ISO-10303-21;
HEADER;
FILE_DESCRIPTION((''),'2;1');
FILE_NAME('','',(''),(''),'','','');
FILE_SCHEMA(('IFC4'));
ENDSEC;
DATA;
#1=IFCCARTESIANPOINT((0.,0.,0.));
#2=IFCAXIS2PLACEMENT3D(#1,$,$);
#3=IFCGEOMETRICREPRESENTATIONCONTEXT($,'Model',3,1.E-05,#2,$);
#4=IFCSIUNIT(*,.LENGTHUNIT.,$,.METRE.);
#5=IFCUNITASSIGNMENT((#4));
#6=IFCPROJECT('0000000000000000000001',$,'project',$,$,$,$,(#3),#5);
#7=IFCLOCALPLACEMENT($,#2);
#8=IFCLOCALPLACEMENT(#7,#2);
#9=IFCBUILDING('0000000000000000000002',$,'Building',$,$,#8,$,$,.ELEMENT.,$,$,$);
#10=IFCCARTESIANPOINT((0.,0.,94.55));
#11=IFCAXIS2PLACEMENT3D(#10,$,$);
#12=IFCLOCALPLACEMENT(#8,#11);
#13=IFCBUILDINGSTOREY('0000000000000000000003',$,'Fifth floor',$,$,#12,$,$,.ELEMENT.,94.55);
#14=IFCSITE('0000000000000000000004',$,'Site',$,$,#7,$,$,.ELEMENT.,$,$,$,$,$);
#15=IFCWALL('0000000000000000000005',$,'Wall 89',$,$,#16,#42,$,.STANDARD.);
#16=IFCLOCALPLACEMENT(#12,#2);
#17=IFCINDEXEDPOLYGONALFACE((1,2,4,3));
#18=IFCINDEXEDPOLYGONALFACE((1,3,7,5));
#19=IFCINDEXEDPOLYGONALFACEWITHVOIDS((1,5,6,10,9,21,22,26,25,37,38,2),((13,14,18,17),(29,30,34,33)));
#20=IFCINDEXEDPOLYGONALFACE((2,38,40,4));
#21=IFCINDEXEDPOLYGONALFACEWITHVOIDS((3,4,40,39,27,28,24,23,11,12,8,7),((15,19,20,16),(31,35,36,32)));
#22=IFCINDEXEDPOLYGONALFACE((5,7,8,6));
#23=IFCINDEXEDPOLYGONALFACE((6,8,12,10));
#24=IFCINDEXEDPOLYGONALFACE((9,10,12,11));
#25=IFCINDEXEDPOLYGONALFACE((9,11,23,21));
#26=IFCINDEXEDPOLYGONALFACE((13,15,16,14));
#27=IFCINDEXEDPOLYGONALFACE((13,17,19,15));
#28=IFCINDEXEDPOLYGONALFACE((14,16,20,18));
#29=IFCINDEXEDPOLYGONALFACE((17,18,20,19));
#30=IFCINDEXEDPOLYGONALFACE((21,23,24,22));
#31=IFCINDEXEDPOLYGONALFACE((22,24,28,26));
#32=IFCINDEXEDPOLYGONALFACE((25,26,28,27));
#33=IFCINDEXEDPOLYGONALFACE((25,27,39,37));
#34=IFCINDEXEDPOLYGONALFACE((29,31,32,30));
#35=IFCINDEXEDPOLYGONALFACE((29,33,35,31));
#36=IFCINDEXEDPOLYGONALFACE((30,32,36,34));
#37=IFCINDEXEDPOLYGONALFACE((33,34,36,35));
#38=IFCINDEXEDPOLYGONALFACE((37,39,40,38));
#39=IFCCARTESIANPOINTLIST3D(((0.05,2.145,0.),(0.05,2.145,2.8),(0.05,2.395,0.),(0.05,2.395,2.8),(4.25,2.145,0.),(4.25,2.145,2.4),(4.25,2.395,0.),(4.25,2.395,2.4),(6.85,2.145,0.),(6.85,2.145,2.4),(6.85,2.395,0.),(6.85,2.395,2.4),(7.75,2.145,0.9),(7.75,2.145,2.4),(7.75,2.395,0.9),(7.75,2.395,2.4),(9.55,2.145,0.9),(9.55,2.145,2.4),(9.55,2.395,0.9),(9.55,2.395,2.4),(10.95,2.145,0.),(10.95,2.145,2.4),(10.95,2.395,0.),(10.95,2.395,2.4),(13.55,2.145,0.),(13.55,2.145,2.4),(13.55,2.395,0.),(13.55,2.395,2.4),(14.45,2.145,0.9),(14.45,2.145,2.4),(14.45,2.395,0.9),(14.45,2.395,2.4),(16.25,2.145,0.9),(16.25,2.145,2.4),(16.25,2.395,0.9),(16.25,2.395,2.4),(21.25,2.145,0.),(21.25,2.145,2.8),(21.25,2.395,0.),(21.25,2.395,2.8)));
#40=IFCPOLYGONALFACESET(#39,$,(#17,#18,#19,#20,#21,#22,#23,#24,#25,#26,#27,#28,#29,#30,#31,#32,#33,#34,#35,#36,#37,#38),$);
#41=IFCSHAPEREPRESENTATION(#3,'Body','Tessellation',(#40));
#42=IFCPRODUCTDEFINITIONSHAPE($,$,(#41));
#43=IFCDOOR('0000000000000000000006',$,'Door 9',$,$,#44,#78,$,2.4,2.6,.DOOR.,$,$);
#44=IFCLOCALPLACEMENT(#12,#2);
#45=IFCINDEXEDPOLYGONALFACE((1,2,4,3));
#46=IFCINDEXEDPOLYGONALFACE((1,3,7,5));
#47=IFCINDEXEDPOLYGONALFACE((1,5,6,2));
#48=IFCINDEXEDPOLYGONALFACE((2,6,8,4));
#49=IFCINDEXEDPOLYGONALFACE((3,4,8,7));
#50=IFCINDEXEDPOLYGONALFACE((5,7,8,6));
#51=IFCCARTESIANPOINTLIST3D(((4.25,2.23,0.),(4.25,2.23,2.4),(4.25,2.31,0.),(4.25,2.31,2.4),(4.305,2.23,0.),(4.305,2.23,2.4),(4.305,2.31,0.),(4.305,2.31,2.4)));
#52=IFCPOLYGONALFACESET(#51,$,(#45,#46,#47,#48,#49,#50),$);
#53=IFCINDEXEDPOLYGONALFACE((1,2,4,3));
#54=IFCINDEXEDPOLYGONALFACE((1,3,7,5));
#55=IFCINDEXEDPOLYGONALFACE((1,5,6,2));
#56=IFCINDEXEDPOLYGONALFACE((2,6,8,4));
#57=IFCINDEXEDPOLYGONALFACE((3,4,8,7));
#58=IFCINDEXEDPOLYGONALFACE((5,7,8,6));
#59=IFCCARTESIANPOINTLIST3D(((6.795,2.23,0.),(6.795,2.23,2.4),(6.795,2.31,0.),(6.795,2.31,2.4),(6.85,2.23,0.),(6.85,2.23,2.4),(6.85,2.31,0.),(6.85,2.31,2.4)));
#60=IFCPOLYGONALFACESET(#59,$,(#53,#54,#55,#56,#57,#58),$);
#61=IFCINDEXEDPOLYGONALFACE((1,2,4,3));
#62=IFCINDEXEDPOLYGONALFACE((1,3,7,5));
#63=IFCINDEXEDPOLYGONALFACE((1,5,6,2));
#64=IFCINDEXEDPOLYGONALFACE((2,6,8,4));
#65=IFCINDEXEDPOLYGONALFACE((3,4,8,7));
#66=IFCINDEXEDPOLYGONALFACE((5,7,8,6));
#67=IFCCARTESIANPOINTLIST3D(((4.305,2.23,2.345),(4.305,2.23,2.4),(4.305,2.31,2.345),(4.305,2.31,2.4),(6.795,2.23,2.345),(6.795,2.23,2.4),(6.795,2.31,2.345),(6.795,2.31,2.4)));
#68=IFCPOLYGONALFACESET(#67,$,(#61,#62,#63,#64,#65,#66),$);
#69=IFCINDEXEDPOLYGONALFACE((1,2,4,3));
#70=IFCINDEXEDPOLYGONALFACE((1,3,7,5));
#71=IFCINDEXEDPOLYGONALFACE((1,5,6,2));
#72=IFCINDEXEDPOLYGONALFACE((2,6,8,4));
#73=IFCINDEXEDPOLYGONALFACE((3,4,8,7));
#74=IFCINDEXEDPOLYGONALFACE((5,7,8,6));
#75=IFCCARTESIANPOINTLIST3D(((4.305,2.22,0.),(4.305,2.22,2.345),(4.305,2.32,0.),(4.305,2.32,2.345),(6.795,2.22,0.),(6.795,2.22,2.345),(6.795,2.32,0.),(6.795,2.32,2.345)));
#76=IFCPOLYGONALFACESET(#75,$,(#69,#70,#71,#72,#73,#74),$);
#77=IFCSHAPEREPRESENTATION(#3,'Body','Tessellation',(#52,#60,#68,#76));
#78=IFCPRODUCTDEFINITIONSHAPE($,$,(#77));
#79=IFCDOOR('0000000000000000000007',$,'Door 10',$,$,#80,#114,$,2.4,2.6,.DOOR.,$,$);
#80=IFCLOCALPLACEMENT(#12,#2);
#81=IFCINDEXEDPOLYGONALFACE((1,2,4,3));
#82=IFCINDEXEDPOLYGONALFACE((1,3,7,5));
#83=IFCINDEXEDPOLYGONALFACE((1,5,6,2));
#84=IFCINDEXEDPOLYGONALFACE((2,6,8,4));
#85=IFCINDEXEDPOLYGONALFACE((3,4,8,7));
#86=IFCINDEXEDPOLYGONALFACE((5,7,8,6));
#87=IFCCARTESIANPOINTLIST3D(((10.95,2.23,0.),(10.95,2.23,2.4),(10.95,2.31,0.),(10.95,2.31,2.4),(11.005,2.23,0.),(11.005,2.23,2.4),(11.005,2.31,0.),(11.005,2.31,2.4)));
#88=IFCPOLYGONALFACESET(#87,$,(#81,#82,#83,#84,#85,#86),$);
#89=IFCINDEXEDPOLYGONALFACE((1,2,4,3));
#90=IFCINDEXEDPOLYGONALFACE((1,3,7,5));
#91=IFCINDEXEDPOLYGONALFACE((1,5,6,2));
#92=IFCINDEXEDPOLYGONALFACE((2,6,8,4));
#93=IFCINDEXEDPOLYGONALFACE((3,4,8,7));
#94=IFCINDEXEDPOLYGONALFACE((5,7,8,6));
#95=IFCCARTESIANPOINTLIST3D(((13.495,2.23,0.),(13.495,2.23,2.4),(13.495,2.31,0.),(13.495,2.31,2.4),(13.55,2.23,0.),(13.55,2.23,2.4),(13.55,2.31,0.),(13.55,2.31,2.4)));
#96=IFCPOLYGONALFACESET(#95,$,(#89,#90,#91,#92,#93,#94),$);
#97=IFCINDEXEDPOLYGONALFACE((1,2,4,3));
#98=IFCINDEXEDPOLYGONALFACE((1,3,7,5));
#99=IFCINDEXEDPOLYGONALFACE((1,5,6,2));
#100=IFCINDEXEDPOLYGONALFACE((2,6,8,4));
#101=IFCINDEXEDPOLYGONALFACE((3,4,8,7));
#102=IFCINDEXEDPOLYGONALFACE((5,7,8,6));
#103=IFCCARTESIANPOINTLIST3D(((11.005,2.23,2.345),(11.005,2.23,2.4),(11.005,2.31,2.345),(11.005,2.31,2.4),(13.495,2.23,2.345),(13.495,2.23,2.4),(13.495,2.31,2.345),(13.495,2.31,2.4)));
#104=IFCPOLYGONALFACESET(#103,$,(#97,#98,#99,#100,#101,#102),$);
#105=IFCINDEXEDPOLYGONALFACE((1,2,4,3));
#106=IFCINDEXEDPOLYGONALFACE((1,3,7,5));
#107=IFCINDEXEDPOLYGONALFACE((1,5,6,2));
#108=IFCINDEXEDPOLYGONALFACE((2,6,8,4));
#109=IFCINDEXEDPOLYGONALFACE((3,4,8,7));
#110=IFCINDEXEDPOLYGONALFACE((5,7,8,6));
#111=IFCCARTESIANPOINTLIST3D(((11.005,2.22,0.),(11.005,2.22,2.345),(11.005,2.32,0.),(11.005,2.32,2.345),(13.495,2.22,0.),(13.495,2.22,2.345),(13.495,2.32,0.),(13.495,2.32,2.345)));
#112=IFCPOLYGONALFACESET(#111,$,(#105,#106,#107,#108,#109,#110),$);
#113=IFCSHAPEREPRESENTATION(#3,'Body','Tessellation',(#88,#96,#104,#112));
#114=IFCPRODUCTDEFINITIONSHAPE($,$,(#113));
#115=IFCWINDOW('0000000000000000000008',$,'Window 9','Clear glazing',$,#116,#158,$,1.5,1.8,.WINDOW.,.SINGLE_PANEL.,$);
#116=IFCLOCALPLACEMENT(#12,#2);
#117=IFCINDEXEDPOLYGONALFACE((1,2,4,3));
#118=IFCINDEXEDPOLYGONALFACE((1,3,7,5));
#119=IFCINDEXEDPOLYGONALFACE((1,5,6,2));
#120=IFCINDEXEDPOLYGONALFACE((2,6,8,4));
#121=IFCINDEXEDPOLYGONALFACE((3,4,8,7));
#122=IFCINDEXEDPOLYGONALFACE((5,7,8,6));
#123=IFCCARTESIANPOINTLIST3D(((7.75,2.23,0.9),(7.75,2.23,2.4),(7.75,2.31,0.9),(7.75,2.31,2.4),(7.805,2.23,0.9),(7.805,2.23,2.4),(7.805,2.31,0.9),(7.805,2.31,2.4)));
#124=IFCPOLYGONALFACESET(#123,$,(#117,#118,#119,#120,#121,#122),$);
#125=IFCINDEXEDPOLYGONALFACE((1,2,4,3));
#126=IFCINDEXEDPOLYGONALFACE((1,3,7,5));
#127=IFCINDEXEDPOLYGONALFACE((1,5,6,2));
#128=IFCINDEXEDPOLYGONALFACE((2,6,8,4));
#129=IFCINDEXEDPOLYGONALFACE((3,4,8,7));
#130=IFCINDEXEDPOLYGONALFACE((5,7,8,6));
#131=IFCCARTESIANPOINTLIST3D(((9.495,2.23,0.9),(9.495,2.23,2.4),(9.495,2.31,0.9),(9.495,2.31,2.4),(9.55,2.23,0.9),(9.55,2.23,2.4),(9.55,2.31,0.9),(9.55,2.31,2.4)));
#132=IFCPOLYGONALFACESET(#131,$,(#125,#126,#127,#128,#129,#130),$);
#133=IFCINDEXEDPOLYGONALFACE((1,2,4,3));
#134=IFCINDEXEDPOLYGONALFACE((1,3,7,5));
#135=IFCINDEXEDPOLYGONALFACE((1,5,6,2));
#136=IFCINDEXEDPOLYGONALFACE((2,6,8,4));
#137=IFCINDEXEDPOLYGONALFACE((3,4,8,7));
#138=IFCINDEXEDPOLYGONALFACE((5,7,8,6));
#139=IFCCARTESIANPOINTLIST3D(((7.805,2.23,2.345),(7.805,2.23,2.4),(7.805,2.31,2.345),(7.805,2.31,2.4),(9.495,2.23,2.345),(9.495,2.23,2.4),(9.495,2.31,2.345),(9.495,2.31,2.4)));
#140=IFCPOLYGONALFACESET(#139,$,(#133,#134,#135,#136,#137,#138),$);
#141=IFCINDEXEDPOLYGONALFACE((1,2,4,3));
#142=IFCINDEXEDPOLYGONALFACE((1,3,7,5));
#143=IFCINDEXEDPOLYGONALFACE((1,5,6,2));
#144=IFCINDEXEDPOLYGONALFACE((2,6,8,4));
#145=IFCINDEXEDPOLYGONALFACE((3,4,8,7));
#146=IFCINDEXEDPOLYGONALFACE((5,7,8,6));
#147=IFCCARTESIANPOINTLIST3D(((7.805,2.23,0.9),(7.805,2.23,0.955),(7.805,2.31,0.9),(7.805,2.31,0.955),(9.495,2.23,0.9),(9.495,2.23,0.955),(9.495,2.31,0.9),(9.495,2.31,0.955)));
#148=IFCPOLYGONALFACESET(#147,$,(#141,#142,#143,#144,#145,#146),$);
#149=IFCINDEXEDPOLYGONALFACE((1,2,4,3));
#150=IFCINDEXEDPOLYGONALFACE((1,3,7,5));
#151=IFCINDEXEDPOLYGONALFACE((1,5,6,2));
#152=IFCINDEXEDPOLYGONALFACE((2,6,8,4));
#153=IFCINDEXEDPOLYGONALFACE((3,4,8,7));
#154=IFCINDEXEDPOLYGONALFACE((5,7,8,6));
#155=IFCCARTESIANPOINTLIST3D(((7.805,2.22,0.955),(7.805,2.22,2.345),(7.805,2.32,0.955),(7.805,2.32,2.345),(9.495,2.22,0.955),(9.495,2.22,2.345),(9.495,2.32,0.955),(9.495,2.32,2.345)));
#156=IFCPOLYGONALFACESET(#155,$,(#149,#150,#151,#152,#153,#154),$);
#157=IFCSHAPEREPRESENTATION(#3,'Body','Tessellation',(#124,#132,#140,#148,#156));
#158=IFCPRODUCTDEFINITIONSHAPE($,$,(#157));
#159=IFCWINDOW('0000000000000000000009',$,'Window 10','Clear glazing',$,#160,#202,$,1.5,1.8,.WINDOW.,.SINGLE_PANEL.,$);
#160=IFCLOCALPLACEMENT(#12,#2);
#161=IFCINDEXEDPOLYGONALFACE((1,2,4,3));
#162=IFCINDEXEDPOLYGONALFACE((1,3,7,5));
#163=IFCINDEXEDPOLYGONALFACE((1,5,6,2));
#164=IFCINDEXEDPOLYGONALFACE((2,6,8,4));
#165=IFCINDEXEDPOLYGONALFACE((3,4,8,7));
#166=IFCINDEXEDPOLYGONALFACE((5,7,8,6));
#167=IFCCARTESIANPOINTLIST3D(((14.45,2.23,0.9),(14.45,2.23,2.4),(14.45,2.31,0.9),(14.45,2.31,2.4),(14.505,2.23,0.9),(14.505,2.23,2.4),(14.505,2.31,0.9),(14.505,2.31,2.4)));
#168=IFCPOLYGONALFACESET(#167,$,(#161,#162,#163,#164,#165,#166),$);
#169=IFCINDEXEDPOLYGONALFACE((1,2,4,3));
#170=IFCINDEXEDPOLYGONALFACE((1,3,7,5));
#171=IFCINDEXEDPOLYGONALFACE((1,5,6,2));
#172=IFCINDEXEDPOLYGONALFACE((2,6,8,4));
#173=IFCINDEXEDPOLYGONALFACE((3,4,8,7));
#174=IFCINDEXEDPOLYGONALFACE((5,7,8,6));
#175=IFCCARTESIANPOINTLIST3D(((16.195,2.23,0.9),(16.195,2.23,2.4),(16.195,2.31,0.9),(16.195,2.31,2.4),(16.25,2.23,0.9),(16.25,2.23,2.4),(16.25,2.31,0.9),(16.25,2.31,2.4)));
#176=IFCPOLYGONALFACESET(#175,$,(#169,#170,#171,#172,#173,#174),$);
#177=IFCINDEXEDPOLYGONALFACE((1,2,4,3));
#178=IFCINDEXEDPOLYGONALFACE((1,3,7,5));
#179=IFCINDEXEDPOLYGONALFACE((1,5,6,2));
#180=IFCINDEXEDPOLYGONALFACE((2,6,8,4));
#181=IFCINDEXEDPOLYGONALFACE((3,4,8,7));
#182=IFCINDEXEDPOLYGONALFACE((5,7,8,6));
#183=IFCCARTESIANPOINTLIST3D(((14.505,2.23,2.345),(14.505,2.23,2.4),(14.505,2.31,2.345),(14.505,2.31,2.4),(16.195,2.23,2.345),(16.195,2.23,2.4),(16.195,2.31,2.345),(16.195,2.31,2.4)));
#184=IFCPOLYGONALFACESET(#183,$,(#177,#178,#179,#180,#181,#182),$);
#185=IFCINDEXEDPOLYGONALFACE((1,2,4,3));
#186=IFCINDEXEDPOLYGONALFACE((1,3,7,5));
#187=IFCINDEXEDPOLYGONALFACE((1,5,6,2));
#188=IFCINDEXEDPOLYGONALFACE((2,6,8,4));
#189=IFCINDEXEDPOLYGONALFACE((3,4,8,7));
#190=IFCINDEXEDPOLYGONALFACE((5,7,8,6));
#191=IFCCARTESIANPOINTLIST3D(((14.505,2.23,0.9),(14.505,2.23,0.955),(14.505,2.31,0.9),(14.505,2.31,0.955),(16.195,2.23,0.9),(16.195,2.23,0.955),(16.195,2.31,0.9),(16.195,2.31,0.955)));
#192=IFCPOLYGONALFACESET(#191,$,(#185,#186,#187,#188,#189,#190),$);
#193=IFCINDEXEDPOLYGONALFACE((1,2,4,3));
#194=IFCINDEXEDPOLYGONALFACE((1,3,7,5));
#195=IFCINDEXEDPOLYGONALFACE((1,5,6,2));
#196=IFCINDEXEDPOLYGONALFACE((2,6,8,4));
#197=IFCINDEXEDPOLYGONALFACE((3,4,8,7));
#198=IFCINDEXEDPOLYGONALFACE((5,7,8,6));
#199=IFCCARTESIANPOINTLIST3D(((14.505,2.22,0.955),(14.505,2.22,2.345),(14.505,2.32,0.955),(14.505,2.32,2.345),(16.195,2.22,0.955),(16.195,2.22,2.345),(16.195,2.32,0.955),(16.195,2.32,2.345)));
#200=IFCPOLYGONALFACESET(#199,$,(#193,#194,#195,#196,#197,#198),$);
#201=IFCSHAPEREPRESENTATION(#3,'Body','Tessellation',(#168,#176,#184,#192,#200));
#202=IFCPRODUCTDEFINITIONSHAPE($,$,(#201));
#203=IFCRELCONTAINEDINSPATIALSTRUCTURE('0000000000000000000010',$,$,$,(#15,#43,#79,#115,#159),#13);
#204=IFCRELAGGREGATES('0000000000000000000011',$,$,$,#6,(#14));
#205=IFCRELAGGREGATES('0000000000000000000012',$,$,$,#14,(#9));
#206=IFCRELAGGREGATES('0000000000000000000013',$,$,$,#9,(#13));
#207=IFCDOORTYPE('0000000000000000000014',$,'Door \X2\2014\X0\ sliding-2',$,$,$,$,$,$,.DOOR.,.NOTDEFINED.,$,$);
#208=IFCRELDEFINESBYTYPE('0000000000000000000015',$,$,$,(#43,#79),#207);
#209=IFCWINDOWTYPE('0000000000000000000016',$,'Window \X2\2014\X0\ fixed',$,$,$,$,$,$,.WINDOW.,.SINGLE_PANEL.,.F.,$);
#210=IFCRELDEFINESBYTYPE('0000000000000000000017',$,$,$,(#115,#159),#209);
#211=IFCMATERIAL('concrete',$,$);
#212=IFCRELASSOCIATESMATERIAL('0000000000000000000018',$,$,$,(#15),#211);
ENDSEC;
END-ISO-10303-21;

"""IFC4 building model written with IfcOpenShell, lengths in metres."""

from ifc_helpers import new_model, si_unit, frame, frame_2d, origin, place, context, project, spatial, rectangle, extrude, material, type_object, element, fill, save


model = new_model("IFC4")

# Units and contexts
model_context = context("Model", 3, precision=1e-05, world=origin())
ifc_project = project(units=[si_unit("LENGTHUNIT", "METRE")], contexts=[model_context])

# Site, building, storey
site_placement = place(None, origin())
site = spatial("IfcSite", under=ifc_project, at=site_placement, Name="Site", CompositionType="ELEMENT")
building_placement = place(site_placement, origin())
building = spatial("IfcBuilding", under=site, at=building_placement, Name="Building", CompositionType="ELEMENT")
storey_placement = place(building_placement, frame((0.0, 0.0, 94.55)))
storey = spatial("IfcBuildingStorey", under=building, at=storey_placement, Name="Fifth floor", CompositionType="ELEMENT", Elevation=94.55)

# Shared definitions
ifc_material = material(Name="concrete")

# Wall, openings, doors, windows
wall_1_placement = place(storey_placement, frame((0.05, 2.27, 0.0), z_axis=(0.0, 0.0, 1.0), x_axis=(1.0, 0.0, 0.0)))
wall_1 = element("IfcWall", 1, at=wall_1_placement, inside=storey, material=ifc_material, Name="Wall 89", PredefinedType="STANDARD", context=model_context, shape_type="SweptSolid", body=[
    extrude(rectangle(XDim=21.2, YDim=0.25, at=frame_2d((10.6, 0.0))), origin(), (0.0, 0.0, 1.0), 2.8),
])
opening_1_placement = place(storey_placement, frame((4.25, 2.27, 0.0), z_axis=(0.0, 0.0, 1.0), x_axis=(1.0, 0.0, 0.0)))
opening_1 = element("IfcOpeningElement", 2, at=opening_1_placement, cuts=wall_1, PredefinedType="OPENING", context=model_context, shape_type="SweptSolid", body=[
    extrude(rectangle(XDim=2.6, YDim=0.31, at=frame_2d((1.3, 0.0))), origin(), (0.0, 0.0, 1.0), 2.4),
])
opening_2_placement = place(storey_placement, frame((7.75, 2.27, 0.9), z_axis=(0.0, 0.0, 1.0), x_axis=(1.0, 0.0, 0.0)))
opening_2 = element("IfcOpeningElement", 3, at=opening_2_placement, cuts=wall_1, PredefinedType="OPENING", context=model_context, shape_type="SweptSolid", body=[
    extrude(rectangle(XDim=1.8, YDim=0.31, at=frame_2d((0.9, 0.0))), origin(), (0.0, 0.0, 1.0), 1.5),
])
opening_3_placement = place(storey_placement, frame((10.95, 2.27, 0.0), z_axis=(0.0, 0.0, 1.0), x_axis=(1.0, 0.0, 0.0)))
opening_3 = element("IfcOpeningElement", 4, at=opening_3_placement, cuts=wall_1, PredefinedType="OPENING", context=model_context, shape_type="SweptSolid", body=[
    extrude(rectangle(XDim=2.6, YDim=0.31, at=frame_2d((1.3, 0.0))), origin(), (0.0, 0.0, 1.0), 2.4),
])
opening_4_placement = place(storey_placement, frame((14.45, 2.27, 0.9), z_axis=(0.0, 0.0, 1.0), x_axis=(1.0, 0.0, 0.0)))
opening_4 = element("IfcOpeningElement", 5, at=opening_4_placement, cuts=wall_1, PredefinedType="OPENING", context=model_context, shape_type="SweptSolid", body=[
    extrude(rectangle(XDim=1.8, YDim=0.31, at=frame_2d((0.9, 0.0))), origin(), (0.0, 0.0, 1.0), 1.5),
])
door_type = type_object("IfcDoorType", Name="Door — sliding-2", PredefinedType="DOOR")
door_1_placement = place(storey_placement, frame((4.25, 2.27, 0.0), z_axis=(0.0, 0.0, 1.0), x_axis=(1.0, 0.0, 0.0)))
door_1 = element("IfcDoor", 6, at=door_1_placement, inside=storey, type_object=door_type, Name="Door 9", OverallHeight=2.4, OverallWidth=2.6, PredefinedType="DOOR", context=model_context, shape_type="SweptSolid", body=[
    extrude(rectangle(XDim=0.055, YDim=0.08, at=frame_2d((0.0275, 0.0))), origin(), (0.0, 0.0, 1.0), 2.4),
    extrude(rectangle(XDim=0.055, YDim=0.08, at=frame_2d((2.5725, 0.0))), origin(), (0.0, 0.0, 1.0), 2.4),
    extrude(rectangle(XDim=2.49, YDim=0.08, at=frame_2d((1.3, 0.0))), frame((0.0, 0.0, 2.345)), (0.0, 0.0, 1.0), 0.055),
    extrude(rectangle(XDim=2.49, YDim=0.1, at=frame_2d((1.3, 0.0))), origin(), (0.0, 0.0, 1.0), 2.345),
])
fill(opening_1, door_1)
door_2_placement = place(storey_placement, frame((10.95, 2.27, 0.0), z_axis=(0.0, 0.0, 1.0), x_axis=(1.0, 0.0, 0.0)))
door_2 = element("IfcDoor", 7, at=door_2_placement, inside=storey, type_object=door_type, Name="Door 10", OverallHeight=2.4, OverallWidth=2.6, PredefinedType="DOOR", context=model_context, shape_type="SweptSolid", body=[
    extrude(rectangle(XDim=0.055, YDim=0.08, at=frame_2d((0.0275, 0.0))), origin(), (0.0, 0.0, 1.0), 2.4),
    extrude(rectangle(XDim=0.055, YDim=0.08, at=frame_2d((2.5725, 0.0))), origin(), (0.0, 0.0, 1.0), 2.4),
    extrude(rectangle(XDim=2.49, YDim=0.08, at=frame_2d((1.3, 0.0))), frame((0.0, 0.0, 2.345)), (0.0, 0.0, 1.0), 0.055),
    extrude(rectangle(XDim=2.49, YDim=0.1, at=frame_2d((1.3, 0.0))), origin(), (0.0, 0.0, 1.0), 2.345),
])
fill(opening_3, door_2)
window_type = type_object("IfcWindowType", Name="Window — fixed", ParameterTakesPrecedence=False, PartitioningType="SINGLE_PANEL", PredefinedType="WINDOW")
window_1_placement = place(storey_placement, frame((7.75, 2.27, 0.9), z_axis=(0.0, 0.0, 1.0), x_axis=(1.0, 0.0, 0.0)))
window_1 = element("IfcWindow", 8, at=window_1_placement, inside=storey, type_object=window_type, Name="Window 9", Description="Clear glazing", OverallHeight=1.5, OverallWidth=1.8, PartitioningType="SINGLE_PANEL", PredefinedType="WINDOW", context=model_context, shape_type="SweptSolid", body=[
    extrude(rectangle(XDim=0.055, YDim=0.08, at=frame_2d((0.0275, 0.0))), origin(), (0.0, 0.0, 1.0), 1.5),
    extrude(rectangle(XDim=0.055, YDim=0.08, at=frame_2d((1.7725, 0.0))), origin(), (0.0, 0.0, 1.0), 1.5),
    extrude(rectangle(XDim=1.69, YDim=0.08, at=frame_2d((0.9, 0.0))), frame((0.0, 0.0, 1.445)), (0.0, 0.0, 1.0), 0.055),
    extrude(rectangle(XDim=1.69, YDim=0.08, at=frame_2d((0.9, 0.0))), origin(), (0.0, 0.0, 1.0), 0.055),
    extrude(rectangle(XDim=1.69, YDim=0.1, at=frame_2d((0.9, 0.0))), frame((0.0, 0.0, 0.055)), (0.0, 0.0, 1.0), 1.39),
])
fill(opening_2, window_1)
window_2_placement = place(storey_placement, frame((14.45, 2.27, 0.9), z_axis=(0.0, 0.0, 1.0), x_axis=(1.0, 0.0, 0.0)))
window_2 = element("IfcWindow", 9, at=window_2_placement, inside=storey, type_object=window_type, Name="Window 10", Description="Clear glazing", OverallHeight=1.5, OverallWidth=1.8, PartitioningType="SINGLE_PANEL", PredefinedType="WINDOW", context=model_context, shape_type="SweptSolid", body=[
    extrude(rectangle(XDim=0.055, YDim=0.08, at=frame_2d((0.0275, 0.0))), origin(), (0.0, 0.0, 1.0), 1.5),
    extrude(rectangle(XDim=0.055, YDim=0.08, at=frame_2d((1.7725, 0.0))), origin(), (0.0, 0.0, 1.0), 1.5),
    extrude(rectangle(XDim=1.69, YDim=0.08, at=frame_2d((0.9, 0.0))), frame((0.0, 0.0, 1.445)), (0.0, 0.0, 1.0), 0.055),
    extrude(rectangle(XDim=1.69, YDim=0.08, at=frame_2d((0.9, 0.0))), origin(), (0.0, 0.0, 1.0), 0.055),
    extrude(rectangle(XDim=1.69, YDim=0.1, at=frame_2d((0.9, 0.0))), frame((0.0, 0.0, 0.055)), (0.0, 0.0, 1.0), 1.39),
])
fill(opening_4, window_2)

save(model, "model.ifc")
